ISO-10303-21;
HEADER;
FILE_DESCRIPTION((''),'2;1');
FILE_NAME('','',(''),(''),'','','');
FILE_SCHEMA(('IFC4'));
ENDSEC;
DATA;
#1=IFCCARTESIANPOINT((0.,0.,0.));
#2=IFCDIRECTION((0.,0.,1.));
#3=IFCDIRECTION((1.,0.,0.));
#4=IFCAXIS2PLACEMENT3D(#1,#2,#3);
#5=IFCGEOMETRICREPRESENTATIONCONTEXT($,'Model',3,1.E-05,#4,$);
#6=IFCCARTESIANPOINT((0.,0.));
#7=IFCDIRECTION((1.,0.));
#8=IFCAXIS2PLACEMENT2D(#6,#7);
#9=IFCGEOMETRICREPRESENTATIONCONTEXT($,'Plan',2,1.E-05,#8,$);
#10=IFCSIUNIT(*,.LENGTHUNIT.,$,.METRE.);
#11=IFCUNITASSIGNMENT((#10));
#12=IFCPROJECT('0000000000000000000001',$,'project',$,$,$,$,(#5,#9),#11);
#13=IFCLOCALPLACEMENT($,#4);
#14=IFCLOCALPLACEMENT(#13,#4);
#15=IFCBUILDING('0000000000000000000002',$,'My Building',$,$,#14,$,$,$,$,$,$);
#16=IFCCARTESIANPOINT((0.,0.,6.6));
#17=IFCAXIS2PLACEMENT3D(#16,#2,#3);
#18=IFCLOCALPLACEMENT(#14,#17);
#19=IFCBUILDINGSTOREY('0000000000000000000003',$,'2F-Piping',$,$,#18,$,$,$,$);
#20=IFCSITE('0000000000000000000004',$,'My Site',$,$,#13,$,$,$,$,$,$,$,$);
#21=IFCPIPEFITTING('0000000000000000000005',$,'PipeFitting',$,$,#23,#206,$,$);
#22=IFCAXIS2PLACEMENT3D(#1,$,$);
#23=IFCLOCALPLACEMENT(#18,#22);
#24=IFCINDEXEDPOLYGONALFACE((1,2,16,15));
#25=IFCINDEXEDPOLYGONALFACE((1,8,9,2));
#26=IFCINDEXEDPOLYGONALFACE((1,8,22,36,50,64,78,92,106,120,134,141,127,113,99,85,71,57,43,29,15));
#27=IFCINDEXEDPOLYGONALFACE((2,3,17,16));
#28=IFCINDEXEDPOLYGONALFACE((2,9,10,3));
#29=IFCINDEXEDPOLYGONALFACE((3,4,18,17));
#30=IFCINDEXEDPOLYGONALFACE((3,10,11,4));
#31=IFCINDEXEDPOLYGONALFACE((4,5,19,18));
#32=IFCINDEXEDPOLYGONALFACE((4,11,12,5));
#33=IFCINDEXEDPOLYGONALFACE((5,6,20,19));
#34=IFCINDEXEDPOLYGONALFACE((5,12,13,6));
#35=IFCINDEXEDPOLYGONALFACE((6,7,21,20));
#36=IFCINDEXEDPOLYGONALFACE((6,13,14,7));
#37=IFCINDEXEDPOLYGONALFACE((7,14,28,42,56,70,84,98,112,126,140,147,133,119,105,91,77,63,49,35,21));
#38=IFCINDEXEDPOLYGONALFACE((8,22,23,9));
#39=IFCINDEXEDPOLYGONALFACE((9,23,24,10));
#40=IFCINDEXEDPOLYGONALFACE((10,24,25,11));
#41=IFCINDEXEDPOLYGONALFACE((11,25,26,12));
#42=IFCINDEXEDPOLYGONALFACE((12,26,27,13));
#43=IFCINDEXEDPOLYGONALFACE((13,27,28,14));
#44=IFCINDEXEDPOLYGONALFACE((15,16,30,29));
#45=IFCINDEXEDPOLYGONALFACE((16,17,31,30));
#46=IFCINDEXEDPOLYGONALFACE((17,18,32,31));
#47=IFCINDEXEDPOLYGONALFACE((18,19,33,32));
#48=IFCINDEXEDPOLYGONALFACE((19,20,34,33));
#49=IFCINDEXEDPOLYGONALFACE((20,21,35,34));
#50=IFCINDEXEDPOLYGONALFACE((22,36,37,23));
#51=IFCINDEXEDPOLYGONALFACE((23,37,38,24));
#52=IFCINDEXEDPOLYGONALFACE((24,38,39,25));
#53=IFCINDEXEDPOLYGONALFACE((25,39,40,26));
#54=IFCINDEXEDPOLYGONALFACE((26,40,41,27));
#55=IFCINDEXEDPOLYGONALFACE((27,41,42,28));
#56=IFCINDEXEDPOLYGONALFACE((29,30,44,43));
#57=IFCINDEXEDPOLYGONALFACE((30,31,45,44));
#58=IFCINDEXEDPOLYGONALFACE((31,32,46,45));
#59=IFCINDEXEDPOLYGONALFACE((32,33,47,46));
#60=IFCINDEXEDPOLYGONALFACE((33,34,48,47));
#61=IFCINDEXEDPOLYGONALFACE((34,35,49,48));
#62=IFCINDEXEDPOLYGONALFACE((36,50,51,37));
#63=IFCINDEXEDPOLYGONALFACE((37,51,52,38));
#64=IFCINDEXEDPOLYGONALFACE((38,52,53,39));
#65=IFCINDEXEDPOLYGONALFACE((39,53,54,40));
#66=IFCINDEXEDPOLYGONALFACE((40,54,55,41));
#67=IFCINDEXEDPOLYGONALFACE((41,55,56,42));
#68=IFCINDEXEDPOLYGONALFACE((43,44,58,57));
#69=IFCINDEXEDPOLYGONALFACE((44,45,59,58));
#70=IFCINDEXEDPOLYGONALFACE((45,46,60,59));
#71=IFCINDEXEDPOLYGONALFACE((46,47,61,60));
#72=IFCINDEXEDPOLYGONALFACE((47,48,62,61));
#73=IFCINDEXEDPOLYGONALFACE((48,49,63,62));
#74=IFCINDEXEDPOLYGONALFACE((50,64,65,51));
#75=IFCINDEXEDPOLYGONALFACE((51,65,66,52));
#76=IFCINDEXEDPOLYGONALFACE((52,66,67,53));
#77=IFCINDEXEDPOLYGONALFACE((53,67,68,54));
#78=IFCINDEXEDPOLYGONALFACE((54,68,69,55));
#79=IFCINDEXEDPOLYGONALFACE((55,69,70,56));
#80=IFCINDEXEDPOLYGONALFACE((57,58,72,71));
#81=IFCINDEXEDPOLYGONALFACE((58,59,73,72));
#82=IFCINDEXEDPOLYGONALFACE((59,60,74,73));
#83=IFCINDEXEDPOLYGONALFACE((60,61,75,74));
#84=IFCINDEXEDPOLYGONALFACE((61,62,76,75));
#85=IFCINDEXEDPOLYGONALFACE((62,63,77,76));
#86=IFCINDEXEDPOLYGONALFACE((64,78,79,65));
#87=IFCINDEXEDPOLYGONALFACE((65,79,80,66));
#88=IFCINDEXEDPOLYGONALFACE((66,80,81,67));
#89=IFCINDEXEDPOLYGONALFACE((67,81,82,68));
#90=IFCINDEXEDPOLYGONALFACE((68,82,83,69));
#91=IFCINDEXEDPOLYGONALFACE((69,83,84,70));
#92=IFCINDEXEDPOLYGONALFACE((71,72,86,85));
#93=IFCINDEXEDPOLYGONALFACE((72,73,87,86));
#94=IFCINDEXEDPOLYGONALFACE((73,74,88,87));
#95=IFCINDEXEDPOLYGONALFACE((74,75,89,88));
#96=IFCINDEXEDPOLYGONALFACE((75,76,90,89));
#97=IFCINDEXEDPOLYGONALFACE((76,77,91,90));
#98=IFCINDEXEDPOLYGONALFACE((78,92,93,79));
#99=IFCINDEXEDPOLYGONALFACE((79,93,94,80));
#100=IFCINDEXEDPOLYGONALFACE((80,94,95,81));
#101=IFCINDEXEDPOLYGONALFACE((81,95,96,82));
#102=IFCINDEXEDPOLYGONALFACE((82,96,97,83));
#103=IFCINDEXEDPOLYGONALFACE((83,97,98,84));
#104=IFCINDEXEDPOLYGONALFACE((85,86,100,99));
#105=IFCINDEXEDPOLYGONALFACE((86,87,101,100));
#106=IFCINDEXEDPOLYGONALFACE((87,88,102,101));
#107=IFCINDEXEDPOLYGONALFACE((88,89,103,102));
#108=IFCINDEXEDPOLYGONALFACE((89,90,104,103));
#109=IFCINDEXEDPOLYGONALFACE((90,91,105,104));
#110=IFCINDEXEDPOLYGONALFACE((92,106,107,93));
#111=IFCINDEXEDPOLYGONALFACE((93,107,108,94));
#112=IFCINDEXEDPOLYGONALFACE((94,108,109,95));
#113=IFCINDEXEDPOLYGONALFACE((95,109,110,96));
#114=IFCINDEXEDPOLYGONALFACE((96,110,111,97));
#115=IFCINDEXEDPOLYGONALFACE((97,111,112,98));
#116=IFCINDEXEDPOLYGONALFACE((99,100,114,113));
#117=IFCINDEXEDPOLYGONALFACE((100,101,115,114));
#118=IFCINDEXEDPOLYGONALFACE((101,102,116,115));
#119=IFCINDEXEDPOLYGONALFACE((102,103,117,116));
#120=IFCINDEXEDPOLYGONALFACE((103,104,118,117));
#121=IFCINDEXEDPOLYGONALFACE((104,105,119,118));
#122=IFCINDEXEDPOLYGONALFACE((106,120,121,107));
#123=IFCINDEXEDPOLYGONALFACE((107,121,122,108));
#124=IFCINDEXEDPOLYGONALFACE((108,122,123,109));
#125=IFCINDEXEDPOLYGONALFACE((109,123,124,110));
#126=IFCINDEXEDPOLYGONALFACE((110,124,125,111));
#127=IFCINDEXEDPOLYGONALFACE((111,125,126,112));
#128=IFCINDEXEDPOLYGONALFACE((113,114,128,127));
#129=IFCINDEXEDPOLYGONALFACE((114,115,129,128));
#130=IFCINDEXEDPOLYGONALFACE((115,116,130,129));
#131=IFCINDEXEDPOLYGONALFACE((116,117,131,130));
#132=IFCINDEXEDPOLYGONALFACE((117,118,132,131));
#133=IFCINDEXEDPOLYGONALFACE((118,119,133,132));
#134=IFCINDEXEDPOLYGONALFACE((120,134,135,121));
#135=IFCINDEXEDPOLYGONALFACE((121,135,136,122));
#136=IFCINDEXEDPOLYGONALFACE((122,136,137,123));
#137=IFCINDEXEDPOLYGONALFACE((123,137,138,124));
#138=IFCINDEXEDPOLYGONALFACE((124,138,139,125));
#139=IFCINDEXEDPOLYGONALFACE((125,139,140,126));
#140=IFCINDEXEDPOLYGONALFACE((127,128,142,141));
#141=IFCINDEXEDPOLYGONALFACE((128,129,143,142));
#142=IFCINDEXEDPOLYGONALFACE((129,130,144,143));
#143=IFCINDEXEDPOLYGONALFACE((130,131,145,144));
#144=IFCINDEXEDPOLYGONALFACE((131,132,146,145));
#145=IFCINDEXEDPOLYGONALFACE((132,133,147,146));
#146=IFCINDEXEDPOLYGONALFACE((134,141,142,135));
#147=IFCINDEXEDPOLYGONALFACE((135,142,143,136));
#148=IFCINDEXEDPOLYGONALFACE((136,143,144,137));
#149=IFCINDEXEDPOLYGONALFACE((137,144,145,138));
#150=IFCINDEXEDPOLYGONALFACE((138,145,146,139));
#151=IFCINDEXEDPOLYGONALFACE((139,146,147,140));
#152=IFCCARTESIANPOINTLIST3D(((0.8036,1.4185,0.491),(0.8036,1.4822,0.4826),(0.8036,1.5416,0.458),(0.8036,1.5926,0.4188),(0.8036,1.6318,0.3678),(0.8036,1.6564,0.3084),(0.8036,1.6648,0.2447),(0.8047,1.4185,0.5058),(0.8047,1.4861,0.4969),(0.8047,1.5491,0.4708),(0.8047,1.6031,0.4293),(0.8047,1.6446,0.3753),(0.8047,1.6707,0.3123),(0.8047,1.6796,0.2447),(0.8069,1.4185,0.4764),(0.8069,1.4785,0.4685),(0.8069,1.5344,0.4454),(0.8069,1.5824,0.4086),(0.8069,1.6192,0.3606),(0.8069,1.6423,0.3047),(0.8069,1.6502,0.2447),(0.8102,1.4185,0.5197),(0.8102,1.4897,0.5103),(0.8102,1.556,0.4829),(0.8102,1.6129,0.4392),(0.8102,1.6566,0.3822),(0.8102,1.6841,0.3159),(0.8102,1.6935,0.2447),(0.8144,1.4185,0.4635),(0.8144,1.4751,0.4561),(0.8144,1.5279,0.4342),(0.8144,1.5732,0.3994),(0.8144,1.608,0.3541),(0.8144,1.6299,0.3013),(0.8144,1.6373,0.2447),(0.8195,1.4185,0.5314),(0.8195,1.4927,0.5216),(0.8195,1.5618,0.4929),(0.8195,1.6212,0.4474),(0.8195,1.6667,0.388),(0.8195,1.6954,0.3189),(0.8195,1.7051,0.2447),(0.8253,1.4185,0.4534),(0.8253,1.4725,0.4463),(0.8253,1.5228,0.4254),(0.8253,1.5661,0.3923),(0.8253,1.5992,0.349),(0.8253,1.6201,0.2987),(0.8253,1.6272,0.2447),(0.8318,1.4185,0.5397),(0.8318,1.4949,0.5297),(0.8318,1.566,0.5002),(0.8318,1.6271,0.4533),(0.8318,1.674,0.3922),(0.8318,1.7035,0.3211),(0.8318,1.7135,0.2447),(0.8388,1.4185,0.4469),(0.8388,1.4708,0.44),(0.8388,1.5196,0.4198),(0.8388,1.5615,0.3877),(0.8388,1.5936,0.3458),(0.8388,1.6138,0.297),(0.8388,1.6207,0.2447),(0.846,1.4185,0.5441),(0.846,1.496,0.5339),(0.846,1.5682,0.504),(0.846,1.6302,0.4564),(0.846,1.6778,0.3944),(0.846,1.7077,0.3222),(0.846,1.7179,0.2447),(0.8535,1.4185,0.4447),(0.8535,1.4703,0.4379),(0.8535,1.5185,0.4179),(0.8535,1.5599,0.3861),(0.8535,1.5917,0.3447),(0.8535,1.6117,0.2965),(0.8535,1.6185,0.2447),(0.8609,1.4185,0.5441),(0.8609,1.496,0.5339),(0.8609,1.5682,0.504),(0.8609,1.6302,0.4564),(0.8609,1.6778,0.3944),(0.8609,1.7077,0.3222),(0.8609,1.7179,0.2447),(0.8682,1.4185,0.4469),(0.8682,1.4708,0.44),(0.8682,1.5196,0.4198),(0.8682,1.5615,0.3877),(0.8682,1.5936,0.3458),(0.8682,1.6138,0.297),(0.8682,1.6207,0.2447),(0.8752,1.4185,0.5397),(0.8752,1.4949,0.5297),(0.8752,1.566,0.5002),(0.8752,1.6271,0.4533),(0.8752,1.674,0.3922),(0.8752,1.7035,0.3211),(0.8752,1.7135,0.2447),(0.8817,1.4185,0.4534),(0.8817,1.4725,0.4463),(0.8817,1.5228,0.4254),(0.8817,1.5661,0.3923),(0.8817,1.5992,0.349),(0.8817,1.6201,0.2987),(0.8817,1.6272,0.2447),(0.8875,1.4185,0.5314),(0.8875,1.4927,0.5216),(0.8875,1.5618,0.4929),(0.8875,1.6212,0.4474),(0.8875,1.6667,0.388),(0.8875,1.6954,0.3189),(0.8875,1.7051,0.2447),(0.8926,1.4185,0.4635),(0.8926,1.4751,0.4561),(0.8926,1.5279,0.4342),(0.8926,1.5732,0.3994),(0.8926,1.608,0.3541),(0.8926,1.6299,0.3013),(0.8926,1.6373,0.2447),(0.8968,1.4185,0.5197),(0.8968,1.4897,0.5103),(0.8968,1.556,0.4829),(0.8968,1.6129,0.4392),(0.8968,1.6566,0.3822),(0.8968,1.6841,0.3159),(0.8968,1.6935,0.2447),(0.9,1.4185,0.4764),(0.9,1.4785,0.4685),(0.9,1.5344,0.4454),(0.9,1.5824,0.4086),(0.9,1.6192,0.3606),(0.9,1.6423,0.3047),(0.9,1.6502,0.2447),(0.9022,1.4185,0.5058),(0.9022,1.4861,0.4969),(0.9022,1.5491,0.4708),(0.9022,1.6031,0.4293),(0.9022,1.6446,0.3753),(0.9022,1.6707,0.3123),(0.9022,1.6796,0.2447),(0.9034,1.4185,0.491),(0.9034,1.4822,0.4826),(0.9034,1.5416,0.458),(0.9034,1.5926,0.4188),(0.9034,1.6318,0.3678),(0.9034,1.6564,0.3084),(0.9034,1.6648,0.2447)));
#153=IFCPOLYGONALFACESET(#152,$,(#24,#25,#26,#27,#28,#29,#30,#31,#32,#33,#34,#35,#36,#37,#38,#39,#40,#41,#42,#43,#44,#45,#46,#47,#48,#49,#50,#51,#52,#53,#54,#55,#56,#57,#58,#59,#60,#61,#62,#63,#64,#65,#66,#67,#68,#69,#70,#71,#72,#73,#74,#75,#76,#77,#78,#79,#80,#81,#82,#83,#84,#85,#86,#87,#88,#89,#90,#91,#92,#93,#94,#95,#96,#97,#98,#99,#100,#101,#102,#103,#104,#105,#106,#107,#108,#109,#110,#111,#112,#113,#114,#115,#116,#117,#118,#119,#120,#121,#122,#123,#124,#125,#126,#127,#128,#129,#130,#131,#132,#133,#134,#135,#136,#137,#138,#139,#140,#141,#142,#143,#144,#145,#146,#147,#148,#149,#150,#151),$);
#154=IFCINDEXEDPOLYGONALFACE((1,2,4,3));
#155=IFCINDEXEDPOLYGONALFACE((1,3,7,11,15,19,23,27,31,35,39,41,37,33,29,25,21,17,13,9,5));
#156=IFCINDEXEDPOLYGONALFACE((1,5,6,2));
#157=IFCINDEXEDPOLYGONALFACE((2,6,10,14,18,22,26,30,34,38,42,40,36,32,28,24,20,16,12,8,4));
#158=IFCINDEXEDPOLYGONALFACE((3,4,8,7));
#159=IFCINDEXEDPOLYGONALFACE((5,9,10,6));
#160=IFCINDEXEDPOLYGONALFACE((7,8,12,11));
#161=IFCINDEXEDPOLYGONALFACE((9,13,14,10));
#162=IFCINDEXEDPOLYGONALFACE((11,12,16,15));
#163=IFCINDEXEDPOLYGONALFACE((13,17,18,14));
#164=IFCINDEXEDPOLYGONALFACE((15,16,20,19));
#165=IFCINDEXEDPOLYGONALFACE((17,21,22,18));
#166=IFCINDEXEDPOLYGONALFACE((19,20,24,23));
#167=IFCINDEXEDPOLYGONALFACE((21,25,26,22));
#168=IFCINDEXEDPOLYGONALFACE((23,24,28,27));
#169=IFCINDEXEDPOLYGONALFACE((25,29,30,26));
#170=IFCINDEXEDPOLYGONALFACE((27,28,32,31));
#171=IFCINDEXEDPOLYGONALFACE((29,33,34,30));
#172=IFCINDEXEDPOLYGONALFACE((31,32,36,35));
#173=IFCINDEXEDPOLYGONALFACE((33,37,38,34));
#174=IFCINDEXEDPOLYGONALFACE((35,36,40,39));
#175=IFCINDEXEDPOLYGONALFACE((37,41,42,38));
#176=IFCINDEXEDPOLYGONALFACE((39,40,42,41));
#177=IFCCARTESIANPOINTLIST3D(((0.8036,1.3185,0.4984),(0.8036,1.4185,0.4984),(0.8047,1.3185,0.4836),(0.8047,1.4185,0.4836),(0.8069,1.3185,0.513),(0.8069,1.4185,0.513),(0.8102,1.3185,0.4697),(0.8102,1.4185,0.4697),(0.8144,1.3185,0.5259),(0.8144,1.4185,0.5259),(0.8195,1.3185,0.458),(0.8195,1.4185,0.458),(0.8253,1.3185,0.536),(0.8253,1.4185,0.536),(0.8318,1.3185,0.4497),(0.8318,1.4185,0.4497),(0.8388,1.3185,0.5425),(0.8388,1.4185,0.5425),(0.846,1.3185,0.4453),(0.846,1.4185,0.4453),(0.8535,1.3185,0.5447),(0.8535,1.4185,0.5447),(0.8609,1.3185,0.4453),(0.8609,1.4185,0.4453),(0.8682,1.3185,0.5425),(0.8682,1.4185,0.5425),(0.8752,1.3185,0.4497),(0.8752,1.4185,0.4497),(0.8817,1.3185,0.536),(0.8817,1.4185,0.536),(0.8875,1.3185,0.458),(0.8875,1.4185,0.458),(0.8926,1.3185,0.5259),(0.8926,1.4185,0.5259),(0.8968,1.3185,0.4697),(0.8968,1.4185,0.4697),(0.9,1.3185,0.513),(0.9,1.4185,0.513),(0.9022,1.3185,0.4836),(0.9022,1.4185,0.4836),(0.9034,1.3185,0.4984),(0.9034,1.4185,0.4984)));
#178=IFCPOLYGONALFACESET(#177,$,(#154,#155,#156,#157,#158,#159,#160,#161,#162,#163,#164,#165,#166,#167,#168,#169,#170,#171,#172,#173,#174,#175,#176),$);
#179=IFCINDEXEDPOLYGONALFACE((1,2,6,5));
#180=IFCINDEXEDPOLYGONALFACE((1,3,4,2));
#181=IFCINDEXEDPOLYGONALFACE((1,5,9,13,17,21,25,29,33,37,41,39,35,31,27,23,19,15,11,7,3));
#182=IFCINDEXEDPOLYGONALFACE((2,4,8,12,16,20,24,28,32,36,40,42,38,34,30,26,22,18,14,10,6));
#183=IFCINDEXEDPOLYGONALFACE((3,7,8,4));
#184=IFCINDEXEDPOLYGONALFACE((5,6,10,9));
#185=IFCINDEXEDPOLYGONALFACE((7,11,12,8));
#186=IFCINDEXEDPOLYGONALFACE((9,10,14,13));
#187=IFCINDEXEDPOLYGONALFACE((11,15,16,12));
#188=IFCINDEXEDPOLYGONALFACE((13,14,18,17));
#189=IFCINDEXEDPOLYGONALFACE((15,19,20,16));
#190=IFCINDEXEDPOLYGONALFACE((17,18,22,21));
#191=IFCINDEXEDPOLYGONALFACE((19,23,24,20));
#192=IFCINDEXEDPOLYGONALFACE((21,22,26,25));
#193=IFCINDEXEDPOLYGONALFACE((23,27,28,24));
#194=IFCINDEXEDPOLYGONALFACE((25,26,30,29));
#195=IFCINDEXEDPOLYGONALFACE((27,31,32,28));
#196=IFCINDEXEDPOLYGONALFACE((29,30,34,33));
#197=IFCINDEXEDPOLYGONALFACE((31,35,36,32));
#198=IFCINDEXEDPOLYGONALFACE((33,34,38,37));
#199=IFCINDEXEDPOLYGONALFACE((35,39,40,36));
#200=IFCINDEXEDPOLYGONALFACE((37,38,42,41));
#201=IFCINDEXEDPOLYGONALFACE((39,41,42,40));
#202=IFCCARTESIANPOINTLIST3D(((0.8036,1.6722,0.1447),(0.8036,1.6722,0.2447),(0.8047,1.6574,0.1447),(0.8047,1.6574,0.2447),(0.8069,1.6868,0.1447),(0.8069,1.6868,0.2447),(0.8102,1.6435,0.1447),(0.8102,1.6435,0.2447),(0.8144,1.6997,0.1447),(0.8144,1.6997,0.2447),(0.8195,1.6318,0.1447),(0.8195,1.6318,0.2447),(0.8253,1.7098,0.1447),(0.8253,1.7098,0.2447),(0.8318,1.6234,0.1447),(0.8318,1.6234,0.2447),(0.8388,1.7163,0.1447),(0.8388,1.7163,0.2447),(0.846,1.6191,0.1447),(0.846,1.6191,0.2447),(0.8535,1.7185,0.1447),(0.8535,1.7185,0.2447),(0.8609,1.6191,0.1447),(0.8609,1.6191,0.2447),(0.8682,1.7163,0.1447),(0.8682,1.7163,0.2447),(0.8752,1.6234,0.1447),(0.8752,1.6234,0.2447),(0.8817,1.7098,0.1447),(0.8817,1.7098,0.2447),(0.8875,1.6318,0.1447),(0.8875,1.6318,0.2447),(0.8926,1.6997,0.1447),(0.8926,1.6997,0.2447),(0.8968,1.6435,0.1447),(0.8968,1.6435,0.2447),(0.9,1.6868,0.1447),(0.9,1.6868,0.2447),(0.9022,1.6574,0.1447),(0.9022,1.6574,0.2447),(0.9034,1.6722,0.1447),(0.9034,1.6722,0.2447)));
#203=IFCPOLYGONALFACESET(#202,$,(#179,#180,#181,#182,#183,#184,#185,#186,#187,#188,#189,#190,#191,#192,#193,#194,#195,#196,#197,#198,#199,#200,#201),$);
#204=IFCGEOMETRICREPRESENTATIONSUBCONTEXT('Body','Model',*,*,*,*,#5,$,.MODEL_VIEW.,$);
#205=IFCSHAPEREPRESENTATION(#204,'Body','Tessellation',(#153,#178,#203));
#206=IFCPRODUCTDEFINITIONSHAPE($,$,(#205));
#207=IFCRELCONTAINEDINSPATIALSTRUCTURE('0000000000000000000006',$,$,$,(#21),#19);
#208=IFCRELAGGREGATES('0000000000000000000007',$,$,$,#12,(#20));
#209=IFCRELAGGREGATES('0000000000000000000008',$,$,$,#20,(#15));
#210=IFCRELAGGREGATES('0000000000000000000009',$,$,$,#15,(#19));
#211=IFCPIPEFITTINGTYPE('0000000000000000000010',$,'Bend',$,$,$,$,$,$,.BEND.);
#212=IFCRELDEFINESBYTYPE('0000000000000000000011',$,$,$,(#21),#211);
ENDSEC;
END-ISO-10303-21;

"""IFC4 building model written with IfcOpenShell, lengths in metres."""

from ifc_helpers import new_model, entity, si_unit, frame, origin_with_axes, origin_2d_with_axis, place, context, subcontext, project, spatial, circle, extrude, source, transform, mapped, type_object, type_shapes, element, save


model = new_model("IFC4")

# Units and contexts
model_context = context("Model", 3, precision=1e-05, world=origin_with_axes())
plan_context = context("Plan", 2, precision=1e-05, world=origin_2d_with_axis())
body_context = subcontext(model_context, "Body", "Model", "MODEL_VIEW")
ifc_project = project(units=[si_unit("LENGTHUNIT", "METRE")], contexts=[model_context, plan_context])

# Site, building, storey
site_placement = place(None, origin_with_axes())
site = spatial("IfcSite", under=ifc_project, at=site_placement, Name="My Site")
building_placement = place(site_placement, origin_with_axes())
building = spatial("IfcBuilding", under=site, at=building_placement, Name="My Building")
storey_placement = place(building_placement, frame((0.0, 0.0, 6.6), z_axis=(0.0, 0.0, 1.0), x_axis=(1.0, 0.0, 0.0)))
storey = spatial("IfcBuildingStorey", under=building, at=storey_placement, Name="2F-Piping")

# Pipe fitting
pipe_fitting_type = type_object("IfcPipeFittingType", Name="Bend", PredefinedType="BEND")
shared_shape = source(origin_with_axes(), body_context, "Body", "SolidModel", [
    entity("IfcSweptDiskSolid", entity("IfcIndexedPolyCurve", entity("IfcCartesianPointList3D", [[0.0, 0.0, -0.1], [-0.0732, 0.0, -0.2768], [-0.25, 0.0, -0.35]]), [entity("IfcArcIndex", [1, 2, 3])]), 0.05),
    extrude(circle(Radius=0.05), origin_with_axes(), (0.0, 0.0, -1.0), 0.1),
    extrude(circle(Radius=0.05), frame((-0.25, 0.0, -0.35), z_axis=(-1.0, 0.0, 0.0), x_axis=(0.0, 0.0, -1.0)), (0.0, 0.0, 1.0), 0.1),
])
type_shapes(pipe_fitting_type, [shared_shape])
for number, where, z_axis, x_axis, name in (
    (1, (0.8535, 1.3185, 0.4947), (0.0, -1.0, 0.0), (0.0, 0.0, 1.0), "PipeFitting"),
):
    element("IfcPipeFitting", number, at=place(storey_placement, frame(where, z_axis=z_axis, x_axis=x_axis)), inside=storey, type_object=pipe_fitting_type, Name=name, context=body_context, shape_type="MappedRepresentation", body=[
        mapped(shared_shape, transform((0.0, 0.0, 0.0), x_axis=(1.0, 0.0, 0.0), y_axis=(0.0, 1.0, 0.0), z_axis=(0.0, 0.0, 1.0), scale=1.0)),
    ])

save(model, "model.ifc")
